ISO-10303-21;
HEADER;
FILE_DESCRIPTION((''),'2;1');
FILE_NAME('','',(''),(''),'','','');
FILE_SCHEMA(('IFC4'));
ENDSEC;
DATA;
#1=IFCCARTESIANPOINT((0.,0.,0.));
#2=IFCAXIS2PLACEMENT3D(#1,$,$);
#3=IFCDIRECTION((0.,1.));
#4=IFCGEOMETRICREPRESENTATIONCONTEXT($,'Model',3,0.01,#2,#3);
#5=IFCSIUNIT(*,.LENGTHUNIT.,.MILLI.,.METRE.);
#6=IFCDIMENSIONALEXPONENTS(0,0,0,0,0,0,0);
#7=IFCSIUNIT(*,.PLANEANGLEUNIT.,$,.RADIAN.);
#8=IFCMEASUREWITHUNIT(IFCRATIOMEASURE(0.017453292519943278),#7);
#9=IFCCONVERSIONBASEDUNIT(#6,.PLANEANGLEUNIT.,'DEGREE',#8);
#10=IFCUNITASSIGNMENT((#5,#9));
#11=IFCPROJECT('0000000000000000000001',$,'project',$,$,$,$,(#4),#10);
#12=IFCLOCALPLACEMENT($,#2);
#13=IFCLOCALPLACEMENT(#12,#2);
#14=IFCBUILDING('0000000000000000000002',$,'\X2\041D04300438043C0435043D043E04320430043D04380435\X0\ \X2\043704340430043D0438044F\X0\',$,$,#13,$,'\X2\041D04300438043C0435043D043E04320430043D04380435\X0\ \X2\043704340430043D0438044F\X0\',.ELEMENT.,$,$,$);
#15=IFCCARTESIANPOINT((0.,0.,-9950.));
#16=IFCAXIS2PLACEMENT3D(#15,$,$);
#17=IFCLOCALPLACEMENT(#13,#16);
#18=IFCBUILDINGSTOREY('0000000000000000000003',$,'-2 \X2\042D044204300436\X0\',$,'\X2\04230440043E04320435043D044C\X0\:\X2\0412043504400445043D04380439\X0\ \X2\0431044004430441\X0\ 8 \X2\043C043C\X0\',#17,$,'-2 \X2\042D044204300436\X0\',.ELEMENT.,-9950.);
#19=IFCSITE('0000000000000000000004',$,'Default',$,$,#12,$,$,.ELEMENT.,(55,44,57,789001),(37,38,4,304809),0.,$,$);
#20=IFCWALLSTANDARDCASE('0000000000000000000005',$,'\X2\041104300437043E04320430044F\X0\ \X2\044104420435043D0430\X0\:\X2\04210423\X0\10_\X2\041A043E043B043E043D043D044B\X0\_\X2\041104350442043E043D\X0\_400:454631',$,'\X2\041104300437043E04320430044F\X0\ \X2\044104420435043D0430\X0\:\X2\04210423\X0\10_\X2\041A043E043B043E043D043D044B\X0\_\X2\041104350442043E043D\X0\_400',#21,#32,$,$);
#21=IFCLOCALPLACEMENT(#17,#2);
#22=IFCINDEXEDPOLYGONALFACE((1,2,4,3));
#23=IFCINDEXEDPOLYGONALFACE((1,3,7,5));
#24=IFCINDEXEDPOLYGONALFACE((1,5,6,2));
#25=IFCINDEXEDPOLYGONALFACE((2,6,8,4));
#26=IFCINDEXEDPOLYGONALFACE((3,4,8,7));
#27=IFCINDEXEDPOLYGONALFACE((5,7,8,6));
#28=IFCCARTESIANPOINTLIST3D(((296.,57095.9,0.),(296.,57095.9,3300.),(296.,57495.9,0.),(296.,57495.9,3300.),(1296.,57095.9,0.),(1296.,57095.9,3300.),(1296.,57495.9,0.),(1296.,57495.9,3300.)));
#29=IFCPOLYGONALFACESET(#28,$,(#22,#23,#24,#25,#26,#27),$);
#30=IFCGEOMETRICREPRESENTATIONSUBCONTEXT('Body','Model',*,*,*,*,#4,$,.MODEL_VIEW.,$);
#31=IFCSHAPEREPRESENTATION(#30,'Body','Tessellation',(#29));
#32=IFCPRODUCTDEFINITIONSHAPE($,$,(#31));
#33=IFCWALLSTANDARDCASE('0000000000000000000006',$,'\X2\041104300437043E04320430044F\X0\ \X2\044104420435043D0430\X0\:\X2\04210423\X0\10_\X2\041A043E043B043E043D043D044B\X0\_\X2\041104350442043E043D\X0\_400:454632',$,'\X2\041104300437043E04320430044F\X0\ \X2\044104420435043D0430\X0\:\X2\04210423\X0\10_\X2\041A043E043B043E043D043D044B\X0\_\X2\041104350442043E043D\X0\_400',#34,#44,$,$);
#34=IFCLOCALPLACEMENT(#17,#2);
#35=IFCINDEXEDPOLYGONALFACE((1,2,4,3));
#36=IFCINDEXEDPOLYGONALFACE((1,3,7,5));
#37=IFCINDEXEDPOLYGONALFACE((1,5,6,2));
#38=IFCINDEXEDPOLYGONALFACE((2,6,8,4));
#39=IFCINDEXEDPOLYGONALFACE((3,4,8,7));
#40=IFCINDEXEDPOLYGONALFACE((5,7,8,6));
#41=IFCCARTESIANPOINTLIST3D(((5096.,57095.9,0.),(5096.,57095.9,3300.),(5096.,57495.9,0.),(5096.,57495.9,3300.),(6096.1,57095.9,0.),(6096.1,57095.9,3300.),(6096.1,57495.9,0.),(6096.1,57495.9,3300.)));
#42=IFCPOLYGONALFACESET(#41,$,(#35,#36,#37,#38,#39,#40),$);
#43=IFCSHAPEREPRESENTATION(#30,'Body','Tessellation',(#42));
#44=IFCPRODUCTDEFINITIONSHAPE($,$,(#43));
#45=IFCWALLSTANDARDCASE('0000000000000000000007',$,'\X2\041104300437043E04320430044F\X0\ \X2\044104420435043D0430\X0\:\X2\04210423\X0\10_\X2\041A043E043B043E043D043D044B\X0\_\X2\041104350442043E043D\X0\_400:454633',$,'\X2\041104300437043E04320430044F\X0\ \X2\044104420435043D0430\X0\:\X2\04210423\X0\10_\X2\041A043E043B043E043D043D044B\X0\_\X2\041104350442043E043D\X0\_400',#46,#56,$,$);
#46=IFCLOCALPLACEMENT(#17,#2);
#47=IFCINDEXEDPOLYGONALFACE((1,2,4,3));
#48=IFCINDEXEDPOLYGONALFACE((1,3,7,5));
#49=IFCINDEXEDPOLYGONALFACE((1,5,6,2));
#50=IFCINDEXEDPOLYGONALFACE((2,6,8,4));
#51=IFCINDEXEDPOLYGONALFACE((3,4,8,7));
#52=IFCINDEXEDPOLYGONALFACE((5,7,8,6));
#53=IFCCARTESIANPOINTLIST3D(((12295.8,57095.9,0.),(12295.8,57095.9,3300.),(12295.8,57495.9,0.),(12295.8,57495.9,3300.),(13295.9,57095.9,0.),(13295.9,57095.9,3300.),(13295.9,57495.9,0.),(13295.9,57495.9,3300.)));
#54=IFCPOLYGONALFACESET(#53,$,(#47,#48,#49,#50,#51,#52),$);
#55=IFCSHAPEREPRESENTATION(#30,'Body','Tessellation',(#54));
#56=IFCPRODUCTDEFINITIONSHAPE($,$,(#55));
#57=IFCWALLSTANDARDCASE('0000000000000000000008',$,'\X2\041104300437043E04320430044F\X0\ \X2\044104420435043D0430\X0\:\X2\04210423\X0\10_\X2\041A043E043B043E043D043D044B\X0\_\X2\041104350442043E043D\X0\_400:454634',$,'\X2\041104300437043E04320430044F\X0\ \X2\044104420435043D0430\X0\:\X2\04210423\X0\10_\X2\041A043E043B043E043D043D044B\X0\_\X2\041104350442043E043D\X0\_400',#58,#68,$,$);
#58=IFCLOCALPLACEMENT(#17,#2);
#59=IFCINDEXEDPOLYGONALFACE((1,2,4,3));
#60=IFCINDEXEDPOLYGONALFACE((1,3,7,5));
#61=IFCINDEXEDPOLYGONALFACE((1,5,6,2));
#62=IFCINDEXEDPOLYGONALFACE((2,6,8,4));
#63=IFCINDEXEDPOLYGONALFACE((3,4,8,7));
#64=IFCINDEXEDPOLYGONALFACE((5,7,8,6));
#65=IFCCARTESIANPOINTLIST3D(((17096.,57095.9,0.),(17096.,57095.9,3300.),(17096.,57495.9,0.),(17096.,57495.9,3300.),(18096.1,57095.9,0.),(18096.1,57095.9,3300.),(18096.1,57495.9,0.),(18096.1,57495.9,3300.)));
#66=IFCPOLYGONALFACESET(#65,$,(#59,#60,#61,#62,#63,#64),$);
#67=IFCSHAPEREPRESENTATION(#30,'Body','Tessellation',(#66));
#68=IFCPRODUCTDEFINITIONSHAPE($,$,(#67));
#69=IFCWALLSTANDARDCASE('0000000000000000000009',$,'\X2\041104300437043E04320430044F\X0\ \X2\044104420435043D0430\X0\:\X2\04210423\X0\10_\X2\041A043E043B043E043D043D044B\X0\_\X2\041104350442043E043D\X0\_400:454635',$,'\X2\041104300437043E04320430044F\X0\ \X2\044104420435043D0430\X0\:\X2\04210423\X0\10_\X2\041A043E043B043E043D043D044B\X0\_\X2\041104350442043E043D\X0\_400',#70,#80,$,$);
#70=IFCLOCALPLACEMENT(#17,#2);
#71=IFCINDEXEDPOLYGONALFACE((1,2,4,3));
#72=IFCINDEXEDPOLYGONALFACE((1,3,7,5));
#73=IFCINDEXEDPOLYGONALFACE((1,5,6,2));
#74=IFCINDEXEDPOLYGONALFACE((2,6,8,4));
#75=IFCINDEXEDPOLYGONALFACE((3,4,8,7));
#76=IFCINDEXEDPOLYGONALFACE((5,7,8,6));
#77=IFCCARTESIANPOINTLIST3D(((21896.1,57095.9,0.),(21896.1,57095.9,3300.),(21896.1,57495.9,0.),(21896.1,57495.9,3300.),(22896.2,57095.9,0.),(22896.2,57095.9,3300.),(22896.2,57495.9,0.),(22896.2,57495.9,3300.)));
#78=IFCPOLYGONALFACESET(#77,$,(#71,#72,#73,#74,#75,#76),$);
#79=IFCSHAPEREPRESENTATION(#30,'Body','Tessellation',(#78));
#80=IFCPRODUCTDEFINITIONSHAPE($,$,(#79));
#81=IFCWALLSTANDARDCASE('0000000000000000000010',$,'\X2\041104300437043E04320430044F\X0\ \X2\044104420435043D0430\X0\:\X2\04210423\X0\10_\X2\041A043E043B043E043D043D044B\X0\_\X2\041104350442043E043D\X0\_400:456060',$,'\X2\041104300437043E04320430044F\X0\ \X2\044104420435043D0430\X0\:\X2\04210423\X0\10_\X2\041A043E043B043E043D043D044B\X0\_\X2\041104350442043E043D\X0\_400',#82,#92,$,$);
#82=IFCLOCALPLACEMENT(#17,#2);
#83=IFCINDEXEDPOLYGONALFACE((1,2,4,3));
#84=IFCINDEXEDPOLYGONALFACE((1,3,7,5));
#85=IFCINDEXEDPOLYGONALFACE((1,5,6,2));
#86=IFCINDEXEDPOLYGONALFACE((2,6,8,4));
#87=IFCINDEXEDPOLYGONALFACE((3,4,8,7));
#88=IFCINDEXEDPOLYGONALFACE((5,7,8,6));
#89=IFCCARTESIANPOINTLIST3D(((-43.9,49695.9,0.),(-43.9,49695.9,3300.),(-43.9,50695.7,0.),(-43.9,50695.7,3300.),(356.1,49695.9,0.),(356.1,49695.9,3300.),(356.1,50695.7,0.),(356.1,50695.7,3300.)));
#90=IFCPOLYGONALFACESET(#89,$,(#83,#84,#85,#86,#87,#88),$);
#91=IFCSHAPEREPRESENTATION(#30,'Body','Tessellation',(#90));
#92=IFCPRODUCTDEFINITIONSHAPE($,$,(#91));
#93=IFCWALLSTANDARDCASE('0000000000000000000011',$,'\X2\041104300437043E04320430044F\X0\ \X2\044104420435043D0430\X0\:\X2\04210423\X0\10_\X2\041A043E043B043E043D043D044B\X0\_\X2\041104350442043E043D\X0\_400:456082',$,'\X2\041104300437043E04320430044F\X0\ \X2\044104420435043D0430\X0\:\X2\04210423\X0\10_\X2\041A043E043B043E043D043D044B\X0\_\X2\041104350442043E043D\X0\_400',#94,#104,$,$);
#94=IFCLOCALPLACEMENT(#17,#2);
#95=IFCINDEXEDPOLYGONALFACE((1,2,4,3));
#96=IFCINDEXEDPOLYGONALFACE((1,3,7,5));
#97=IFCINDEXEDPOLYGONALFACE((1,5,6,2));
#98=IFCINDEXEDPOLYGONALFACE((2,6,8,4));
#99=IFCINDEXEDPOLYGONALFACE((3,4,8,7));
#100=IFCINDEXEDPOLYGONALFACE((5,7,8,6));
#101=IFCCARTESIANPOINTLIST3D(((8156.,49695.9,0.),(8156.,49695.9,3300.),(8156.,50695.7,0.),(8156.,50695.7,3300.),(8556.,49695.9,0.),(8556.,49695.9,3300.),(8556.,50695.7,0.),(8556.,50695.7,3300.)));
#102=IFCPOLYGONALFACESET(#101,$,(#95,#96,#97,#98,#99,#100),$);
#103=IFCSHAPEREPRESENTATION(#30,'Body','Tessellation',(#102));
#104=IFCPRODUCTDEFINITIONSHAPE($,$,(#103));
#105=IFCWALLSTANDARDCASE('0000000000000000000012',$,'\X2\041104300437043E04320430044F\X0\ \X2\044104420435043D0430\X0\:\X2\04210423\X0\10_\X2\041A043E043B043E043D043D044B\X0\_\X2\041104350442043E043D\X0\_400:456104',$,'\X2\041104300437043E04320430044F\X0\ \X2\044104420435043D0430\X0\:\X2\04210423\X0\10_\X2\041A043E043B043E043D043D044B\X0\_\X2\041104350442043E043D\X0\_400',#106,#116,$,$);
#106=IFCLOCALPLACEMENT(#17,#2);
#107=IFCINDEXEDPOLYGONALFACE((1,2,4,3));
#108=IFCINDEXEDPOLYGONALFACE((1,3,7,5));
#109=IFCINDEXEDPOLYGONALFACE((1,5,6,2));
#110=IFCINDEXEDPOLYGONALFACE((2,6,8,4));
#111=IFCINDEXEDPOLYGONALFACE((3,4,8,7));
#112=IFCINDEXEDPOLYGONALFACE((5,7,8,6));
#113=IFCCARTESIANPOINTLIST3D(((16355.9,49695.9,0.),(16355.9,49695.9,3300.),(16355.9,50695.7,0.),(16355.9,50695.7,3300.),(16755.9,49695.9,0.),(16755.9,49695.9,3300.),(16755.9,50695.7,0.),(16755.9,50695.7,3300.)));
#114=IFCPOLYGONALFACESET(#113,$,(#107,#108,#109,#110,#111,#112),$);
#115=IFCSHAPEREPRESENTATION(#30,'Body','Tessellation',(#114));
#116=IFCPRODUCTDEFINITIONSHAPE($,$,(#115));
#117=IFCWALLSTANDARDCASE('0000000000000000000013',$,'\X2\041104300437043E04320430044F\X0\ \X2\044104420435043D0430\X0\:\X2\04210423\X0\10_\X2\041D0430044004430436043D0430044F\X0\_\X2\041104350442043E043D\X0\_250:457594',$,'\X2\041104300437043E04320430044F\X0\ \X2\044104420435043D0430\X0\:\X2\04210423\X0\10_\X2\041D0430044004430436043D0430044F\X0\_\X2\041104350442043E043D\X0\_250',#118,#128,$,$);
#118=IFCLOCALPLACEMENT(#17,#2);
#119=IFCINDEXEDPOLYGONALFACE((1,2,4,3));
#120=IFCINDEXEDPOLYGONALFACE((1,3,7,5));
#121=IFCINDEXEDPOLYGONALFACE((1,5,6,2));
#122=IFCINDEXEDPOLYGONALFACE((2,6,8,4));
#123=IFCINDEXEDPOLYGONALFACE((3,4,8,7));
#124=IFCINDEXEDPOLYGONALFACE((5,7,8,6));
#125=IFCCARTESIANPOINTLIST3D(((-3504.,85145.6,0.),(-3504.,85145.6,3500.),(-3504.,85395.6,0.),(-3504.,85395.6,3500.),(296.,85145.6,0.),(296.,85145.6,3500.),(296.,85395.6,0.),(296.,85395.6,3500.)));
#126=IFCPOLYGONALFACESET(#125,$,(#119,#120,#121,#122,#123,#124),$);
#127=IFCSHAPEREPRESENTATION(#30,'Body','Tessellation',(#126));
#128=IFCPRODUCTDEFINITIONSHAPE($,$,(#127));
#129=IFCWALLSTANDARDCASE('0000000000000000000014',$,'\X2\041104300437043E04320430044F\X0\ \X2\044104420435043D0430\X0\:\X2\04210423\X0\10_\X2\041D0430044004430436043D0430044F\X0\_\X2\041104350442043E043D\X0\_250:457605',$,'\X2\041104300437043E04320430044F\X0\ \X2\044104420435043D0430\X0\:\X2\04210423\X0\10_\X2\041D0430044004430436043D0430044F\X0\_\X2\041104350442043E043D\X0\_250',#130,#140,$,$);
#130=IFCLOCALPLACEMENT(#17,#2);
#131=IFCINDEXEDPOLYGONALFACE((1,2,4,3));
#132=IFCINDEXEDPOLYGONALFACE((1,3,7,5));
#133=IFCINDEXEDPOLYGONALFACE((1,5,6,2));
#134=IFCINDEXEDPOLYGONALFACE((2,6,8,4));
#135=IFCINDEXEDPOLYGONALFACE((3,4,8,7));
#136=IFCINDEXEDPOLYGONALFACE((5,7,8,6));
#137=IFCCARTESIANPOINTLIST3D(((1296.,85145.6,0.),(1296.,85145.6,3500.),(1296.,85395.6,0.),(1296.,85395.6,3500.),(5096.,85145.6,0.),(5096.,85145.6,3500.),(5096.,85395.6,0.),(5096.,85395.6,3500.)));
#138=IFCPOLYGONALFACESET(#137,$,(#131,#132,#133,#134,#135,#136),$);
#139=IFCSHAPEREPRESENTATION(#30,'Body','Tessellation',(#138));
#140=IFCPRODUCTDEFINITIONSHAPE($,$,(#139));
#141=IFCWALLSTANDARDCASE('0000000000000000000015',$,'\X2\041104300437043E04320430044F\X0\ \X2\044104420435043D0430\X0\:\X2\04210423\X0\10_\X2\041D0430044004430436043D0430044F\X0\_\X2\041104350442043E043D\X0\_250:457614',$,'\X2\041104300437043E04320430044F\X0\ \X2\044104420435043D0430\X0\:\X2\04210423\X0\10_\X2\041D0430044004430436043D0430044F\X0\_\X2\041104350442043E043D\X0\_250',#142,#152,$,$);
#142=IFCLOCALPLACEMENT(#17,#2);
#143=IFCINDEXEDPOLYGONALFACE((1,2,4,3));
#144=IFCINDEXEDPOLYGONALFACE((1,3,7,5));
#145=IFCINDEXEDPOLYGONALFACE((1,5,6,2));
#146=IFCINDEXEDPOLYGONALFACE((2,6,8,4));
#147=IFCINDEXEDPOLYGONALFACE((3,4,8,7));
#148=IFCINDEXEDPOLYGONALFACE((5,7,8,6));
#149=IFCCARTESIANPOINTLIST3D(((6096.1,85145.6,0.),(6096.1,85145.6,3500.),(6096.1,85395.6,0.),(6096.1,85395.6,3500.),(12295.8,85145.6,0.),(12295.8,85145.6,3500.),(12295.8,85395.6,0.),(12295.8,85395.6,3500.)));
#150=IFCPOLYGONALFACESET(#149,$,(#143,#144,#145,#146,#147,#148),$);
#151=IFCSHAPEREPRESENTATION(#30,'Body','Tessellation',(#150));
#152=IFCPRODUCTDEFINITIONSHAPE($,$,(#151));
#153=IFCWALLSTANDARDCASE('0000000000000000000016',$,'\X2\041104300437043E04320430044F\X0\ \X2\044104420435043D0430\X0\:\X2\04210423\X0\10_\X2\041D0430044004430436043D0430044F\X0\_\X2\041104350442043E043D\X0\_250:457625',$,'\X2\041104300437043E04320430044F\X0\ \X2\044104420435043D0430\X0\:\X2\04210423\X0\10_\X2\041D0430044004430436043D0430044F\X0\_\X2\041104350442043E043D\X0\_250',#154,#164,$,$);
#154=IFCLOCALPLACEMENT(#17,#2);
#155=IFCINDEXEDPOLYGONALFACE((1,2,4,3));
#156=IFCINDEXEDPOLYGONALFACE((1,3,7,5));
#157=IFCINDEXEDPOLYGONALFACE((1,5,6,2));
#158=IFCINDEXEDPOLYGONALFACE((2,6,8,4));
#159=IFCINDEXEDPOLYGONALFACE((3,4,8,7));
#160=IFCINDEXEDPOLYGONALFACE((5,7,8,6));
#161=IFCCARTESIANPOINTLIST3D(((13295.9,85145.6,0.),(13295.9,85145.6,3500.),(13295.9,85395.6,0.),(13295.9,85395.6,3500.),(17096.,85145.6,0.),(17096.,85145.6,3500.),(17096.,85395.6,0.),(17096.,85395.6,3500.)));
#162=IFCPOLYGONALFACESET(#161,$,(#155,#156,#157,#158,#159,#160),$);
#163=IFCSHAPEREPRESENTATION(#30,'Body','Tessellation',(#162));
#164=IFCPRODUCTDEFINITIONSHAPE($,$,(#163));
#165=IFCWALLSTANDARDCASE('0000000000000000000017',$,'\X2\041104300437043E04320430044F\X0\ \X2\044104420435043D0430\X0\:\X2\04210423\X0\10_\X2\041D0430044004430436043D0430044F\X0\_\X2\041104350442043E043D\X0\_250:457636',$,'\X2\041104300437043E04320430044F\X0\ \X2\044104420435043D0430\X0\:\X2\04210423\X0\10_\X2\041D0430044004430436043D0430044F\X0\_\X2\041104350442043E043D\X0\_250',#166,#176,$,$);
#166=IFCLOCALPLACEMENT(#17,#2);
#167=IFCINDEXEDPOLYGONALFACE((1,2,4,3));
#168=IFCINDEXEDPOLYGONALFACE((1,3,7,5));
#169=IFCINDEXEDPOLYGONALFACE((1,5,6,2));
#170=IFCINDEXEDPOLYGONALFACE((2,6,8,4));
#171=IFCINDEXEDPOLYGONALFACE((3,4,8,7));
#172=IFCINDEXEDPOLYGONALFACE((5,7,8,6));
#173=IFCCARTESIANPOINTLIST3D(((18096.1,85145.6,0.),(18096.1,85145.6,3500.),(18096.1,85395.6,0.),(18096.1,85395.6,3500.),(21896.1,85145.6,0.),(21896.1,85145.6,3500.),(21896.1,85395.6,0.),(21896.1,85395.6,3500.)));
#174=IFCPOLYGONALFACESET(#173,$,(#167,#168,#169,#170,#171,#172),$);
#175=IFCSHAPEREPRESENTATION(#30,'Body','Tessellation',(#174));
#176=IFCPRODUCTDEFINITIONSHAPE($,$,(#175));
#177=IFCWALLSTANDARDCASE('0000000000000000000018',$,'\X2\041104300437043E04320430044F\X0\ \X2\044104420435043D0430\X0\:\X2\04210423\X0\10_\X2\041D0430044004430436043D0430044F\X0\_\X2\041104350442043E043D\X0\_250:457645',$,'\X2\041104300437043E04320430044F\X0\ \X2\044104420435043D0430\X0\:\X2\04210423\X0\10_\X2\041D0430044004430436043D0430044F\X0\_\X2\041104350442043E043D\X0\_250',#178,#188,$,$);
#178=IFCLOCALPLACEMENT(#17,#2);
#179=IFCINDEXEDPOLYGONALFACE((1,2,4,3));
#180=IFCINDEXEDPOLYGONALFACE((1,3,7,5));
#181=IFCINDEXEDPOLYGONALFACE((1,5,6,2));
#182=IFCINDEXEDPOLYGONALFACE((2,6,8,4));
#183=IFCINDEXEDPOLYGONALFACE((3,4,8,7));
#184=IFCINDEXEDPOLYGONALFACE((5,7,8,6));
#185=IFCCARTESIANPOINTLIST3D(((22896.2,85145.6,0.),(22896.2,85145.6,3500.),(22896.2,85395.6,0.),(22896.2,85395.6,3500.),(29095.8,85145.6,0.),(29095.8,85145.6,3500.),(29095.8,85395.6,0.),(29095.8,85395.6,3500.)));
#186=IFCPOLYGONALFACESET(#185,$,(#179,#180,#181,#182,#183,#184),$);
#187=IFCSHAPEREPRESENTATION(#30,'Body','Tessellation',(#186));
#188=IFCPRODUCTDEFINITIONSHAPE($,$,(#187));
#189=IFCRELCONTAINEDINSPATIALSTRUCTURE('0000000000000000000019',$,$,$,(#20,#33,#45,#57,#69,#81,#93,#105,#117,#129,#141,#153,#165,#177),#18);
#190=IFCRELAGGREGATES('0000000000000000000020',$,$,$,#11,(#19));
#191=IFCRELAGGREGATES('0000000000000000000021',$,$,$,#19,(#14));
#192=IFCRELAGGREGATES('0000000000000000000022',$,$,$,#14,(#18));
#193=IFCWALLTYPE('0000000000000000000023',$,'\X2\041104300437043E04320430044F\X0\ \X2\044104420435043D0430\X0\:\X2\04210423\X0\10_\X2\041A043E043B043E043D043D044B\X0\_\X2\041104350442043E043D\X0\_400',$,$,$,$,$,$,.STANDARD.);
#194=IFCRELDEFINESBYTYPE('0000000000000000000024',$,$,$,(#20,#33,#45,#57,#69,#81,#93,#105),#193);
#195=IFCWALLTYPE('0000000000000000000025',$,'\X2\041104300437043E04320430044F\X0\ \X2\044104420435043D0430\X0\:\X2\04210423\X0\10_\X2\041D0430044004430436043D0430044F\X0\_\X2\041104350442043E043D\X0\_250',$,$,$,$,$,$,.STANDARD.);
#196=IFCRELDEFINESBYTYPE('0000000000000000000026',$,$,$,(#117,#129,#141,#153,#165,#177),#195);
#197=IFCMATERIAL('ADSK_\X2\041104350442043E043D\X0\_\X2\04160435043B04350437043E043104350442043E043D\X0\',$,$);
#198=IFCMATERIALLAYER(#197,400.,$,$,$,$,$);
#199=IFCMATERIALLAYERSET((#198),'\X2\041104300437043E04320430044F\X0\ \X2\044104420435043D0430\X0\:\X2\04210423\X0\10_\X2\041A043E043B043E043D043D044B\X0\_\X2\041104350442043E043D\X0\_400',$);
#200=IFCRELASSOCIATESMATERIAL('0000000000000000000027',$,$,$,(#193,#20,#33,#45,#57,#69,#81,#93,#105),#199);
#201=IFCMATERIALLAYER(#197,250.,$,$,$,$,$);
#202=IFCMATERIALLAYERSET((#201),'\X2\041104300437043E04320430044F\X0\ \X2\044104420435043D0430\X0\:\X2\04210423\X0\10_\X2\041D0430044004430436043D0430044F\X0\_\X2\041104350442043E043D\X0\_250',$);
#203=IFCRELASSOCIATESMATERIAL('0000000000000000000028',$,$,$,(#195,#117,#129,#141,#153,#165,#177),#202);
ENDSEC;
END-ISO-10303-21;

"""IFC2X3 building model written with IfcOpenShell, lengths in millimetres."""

from ifc_helpers import new_model, entity, si_unit, converted_unit, direction, frame, frame_2d, origin, place, context, subcontext, project, spatial, rectangle, extrude, material, layer, layer_set, layer_usage, type_object, element, save


model = new_model("IFC2X3")

# Units and contexts
model_context = context("Model", 3, precision=0.01, world=origin(), true_north=direction((0.0, 1.0)))
body_context = subcontext(model_context, "Body", "Model", "MODEL_VIEW")
ifc_project = project(units=[si_unit("LENGTHUNIT", "METRE", prefix="MILLI"), converted_unit("PLANEANGLEUNIT", "DEGREE", entity("IfcRatioMeasure", 0.017453292519943278), si_unit("PLANEANGLEUNIT", "RADIAN"), dimensions=[0, 0, 0, 0, 0, 0, 0])], contexts=[model_context])

# Site, building, storey
site_placement = place(None, origin())
site = spatial("IfcSite", under=ifc_project, at=site_placement, Name="Default", CompositionType="ELEMENT", RefLatitude=(55, 44, 57, 789001), RefLongitude=(37, 38, 4, 304809), RefElevation=0.0)
building_placement = place(site_placement, origin())
building = spatial("IfcBuilding", under=site, at=building_placement, Name="Наименование здания", LongName="Наименование здания", CompositionType="ELEMENT")
storey_placement = place(building_placement, frame((0.0, 0.0, -9950.0)))
storey = spatial("IfcBuildingStorey", under=building, at=storey_placement, Name="-2 Этаж", ObjectType="Уровень:Верхний брус 8 мм", LongName="-2 Этаж", CompositionType="ELEMENT", Elevation=-9950.0)

# Walls
ifc_material = material(Name="ADSK_Бетон_Железобетон")
ifc_layer_1 = layer(ifc_material, 400.0)
ifc_layer_set_1 = layer_set([ifc_layer_1], Name="Базовая стена:СУ10_Колонны_Бетон_400")
ifc_layer_usage_1 = layer_usage(ifc_layer_set_1, "AXIS2", "NEGATIVE", 200.0)
wall_type_1 = type_object("IfcWallType", Name="Базовая стена:СУ10_Колонны_Бетон_400", PredefinedType="STANDARD", material=ifc_layer_set_1)
for number, where, name in (
    (1, (296.0, 57295.9, 0.0), "Базовая стена:СУ10_Колонны_Бетон_400:454631"),
    (2, (5096.0, 57295.9, 0.0), "Базовая стена:СУ10_Колонны_Бетон_400:454632"),
    (3, (12295.8, 57295.9, 0.0), "Базовая стена:СУ10_Колонны_Бетон_400:454633"),
    (4, (17096.0, 57295.9, 0.0), "Базовая стена:СУ10_Колонны_Бетон_400:454634"),
    (5, (21896.1, 57295.9, 0.0), "Базовая стена:СУ10_Колонны_Бетон_400:454635"),
):
    element("IfcWallStandardCase", number, at=place(storey_placement, frame(where)), inside=storey, type_object=wall_type_1, material=ifc_layer_usage_1, Name=name, ObjectType="Базовая стена:СУ10_Колонны_Бетон_400", context=body_context, shape_type="SweptSolid", body=[
        extrude(rectangle(XDim=1000.1, YDim=400.0, at=frame_2d((500.0, 0.0), x_axis=(-1.0, 0.0))), origin(), (0.0, 0.0, 1.0), 3300.0),
    ])
for number, where, z_axis, x_axis, name in (
    (6, (156.1, 49695.9, 0.0), (0.0, 0.0, 1.0), (0.0, 1.0, 0.0), "Базовая стена:СУ10_Колонны_Бетон_400:456060"),
    (7, (8356.0, 49695.9, 0.0), (0.0, 0.0, 1.0), (0.0, 1.0, 0.0), "Базовая стена:СУ10_Колонны_Бетон_400:456082"),
    (8, (16555.9, 49695.9, 0.0), (0.0, 0.0, 1.0), (0.0, 1.0, 0.0), "Базовая стена:СУ10_Колонны_Бетон_400:456104"),
):
    element("IfcWallStandardCase", number, at=place(storey_placement, frame(where, z_axis=z_axis, x_axis=x_axis)), inside=storey, type_object=wall_type_1, material=ifc_layer_usage_1, Name=name, ObjectType="Базовая стена:СУ10_Колонны_Бетон_400", context=body_context, shape_type="SweptSolid", body=[
        extrude(rectangle(XDim=999.8, YDim=400.0, at=frame_2d((499.9, 0.0), x_axis=(-1.0, 0.0))), origin(), (0.0, 0.0, 1.0), 3300.0),
    ])
ifc_layer_2 = layer(ifc_material, 250.0)
ifc_layer_set_2 = layer_set([ifc_layer_2], Name="Базовая стена:СУ10_Наружная_Бетон_250")
ifc_layer_usage_2 = layer_usage(ifc_layer_set_2, "AXIS2", "NEGATIVE", 125.0)
wall_type_2 = type_object("IfcWallType", Name="Базовая стена:СУ10_Наружная_Бетон_250", PredefinedType="STANDARD", material=ifc_layer_set_2)
wall_1_placement = place(storey_placement, frame((-3504.0, 85270.6, 0.0)))
element("IfcWallStandardCase", 9, at=wall_1_placement, inside=storey, type_object=wall_type_2, material=ifc_layer_usage_2, Name="Базовая стена:СУ10_Наружная_Бетон_250:457594", ObjectType="Базовая стена:СУ10_Наружная_Бетон_250", context=body_context, shape_type="SweptSolid", body=[
    extrude(rectangle(XDim=3799.9, YDim=250.0, at=frame_2d((1900.0, 0.0), x_axis=(-1.0, 0.0))), origin(), (0.0, 0.0, 1.0), 3500.0),
])
wall_2_placement = place(storey_placement, frame((1296.0, 85270.6, 0.0)))
element("IfcWallStandardCase", 10, at=wall_2_placement, inside=storey, type_object=wall_type_2, material=ifc_layer_usage_2, Name="Базовая стена:СУ10_Наружная_Бетон_250:457605", ObjectType="Базовая стена:СУ10_Наружная_Бетон_250", context=body_context, shape_type="SweptSolid", body=[
    extrude(rectangle(XDim=3800.0, YDim=250.0, at=frame_2d((1900.0, 0.0), x_axis=(-1.0, 0.0))), origin(), (0.0, 0.0, 1.0), 3500.0),
])
wall_3_placement = place(storey_placement, frame((6096.1, 85270.6, 0.0)))
element("IfcWallStandardCase", 11, at=wall_3_placement, inside=storey, type_object=wall_type_2, material=ifc_layer_usage_2, Name="Базовая стена:СУ10_Наружная_Бетон_250:457614", ObjectType="Базовая стена:СУ10_Наружная_Бетон_250", context=body_context, shape_type="SweptSolid", body=[
    extrude(rectangle(XDim=6199.7, YDim=250.0, at=frame_2d((3099.9, 0.0), x_axis=(-1.0, 0.0))), origin(), (0.0, 0.0, 1.0), 3500.0),
])
wall_4_placement = place(storey_placement, frame((13295.9, 85270.6, 0.0)))
element("IfcWallStandardCase", 12, at=wall_4_placement, inside=storey, type_object=wall_type_2, material=ifc_layer_usage_2, Name="Базовая стена:СУ10_Наружная_Бетон_250:457625", ObjectType="Базовая стена:СУ10_Наружная_Бетон_250", context=body_context, shape_type="SweptSolid", body=[
    extrude(rectangle(XDim=3800.1, YDim=250.0, at=frame_2d((1900.0, 0.0), x_axis=(-1.0, 0.0))), origin(), (0.0, 0.0, 1.0), 3500.0),
])
wall_5_placement = place(storey_placement, frame((18096.1, 85270.6, 0.0)))
element("IfcWallStandardCase", 13, at=wall_5_placement, inside=storey, type_object=wall_type_2, material=ifc_layer_usage_2, Name="Базовая стена:СУ10_Наружная_Бетон_250:457636", ObjectType="Базовая стена:СУ10_Наружная_Бетон_250", context=body_context, shape_type="SweptSolid", body=[
    extrude(rectangle(XDim=3800.1, YDim=250.0, at=frame_2d((1900.0, 0.0), x_axis=(-1.0, 0.0))), origin(), (0.0, 0.0, 1.0), 3500.0),
])
wall_6_placement = place(storey_placement, frame((22896.2, 85270.6, 0.0)))
element("IfcWallStandardCase", 14, at=wall_6_placement, inside=storey, type_object=wall_type_2, material=ifc_layer_usage_2, Name="Базовая стена:СУ10_Наружная_Бетон_250:457645", ObjectType="Базовая стена:СУ10_Наружная_Бетон_250", context=body_context, shape_type="SweptSolid", body=[
    extrude(rectangle(XDim=6199.6, YDim=250.0, at=frame_2d((3099.8, 0.0), x_axis=(-1.0, 0.0))), origin(), (0.0, 0.0, 1.0), 3500.0),
])

save(model, "model.ifc")
